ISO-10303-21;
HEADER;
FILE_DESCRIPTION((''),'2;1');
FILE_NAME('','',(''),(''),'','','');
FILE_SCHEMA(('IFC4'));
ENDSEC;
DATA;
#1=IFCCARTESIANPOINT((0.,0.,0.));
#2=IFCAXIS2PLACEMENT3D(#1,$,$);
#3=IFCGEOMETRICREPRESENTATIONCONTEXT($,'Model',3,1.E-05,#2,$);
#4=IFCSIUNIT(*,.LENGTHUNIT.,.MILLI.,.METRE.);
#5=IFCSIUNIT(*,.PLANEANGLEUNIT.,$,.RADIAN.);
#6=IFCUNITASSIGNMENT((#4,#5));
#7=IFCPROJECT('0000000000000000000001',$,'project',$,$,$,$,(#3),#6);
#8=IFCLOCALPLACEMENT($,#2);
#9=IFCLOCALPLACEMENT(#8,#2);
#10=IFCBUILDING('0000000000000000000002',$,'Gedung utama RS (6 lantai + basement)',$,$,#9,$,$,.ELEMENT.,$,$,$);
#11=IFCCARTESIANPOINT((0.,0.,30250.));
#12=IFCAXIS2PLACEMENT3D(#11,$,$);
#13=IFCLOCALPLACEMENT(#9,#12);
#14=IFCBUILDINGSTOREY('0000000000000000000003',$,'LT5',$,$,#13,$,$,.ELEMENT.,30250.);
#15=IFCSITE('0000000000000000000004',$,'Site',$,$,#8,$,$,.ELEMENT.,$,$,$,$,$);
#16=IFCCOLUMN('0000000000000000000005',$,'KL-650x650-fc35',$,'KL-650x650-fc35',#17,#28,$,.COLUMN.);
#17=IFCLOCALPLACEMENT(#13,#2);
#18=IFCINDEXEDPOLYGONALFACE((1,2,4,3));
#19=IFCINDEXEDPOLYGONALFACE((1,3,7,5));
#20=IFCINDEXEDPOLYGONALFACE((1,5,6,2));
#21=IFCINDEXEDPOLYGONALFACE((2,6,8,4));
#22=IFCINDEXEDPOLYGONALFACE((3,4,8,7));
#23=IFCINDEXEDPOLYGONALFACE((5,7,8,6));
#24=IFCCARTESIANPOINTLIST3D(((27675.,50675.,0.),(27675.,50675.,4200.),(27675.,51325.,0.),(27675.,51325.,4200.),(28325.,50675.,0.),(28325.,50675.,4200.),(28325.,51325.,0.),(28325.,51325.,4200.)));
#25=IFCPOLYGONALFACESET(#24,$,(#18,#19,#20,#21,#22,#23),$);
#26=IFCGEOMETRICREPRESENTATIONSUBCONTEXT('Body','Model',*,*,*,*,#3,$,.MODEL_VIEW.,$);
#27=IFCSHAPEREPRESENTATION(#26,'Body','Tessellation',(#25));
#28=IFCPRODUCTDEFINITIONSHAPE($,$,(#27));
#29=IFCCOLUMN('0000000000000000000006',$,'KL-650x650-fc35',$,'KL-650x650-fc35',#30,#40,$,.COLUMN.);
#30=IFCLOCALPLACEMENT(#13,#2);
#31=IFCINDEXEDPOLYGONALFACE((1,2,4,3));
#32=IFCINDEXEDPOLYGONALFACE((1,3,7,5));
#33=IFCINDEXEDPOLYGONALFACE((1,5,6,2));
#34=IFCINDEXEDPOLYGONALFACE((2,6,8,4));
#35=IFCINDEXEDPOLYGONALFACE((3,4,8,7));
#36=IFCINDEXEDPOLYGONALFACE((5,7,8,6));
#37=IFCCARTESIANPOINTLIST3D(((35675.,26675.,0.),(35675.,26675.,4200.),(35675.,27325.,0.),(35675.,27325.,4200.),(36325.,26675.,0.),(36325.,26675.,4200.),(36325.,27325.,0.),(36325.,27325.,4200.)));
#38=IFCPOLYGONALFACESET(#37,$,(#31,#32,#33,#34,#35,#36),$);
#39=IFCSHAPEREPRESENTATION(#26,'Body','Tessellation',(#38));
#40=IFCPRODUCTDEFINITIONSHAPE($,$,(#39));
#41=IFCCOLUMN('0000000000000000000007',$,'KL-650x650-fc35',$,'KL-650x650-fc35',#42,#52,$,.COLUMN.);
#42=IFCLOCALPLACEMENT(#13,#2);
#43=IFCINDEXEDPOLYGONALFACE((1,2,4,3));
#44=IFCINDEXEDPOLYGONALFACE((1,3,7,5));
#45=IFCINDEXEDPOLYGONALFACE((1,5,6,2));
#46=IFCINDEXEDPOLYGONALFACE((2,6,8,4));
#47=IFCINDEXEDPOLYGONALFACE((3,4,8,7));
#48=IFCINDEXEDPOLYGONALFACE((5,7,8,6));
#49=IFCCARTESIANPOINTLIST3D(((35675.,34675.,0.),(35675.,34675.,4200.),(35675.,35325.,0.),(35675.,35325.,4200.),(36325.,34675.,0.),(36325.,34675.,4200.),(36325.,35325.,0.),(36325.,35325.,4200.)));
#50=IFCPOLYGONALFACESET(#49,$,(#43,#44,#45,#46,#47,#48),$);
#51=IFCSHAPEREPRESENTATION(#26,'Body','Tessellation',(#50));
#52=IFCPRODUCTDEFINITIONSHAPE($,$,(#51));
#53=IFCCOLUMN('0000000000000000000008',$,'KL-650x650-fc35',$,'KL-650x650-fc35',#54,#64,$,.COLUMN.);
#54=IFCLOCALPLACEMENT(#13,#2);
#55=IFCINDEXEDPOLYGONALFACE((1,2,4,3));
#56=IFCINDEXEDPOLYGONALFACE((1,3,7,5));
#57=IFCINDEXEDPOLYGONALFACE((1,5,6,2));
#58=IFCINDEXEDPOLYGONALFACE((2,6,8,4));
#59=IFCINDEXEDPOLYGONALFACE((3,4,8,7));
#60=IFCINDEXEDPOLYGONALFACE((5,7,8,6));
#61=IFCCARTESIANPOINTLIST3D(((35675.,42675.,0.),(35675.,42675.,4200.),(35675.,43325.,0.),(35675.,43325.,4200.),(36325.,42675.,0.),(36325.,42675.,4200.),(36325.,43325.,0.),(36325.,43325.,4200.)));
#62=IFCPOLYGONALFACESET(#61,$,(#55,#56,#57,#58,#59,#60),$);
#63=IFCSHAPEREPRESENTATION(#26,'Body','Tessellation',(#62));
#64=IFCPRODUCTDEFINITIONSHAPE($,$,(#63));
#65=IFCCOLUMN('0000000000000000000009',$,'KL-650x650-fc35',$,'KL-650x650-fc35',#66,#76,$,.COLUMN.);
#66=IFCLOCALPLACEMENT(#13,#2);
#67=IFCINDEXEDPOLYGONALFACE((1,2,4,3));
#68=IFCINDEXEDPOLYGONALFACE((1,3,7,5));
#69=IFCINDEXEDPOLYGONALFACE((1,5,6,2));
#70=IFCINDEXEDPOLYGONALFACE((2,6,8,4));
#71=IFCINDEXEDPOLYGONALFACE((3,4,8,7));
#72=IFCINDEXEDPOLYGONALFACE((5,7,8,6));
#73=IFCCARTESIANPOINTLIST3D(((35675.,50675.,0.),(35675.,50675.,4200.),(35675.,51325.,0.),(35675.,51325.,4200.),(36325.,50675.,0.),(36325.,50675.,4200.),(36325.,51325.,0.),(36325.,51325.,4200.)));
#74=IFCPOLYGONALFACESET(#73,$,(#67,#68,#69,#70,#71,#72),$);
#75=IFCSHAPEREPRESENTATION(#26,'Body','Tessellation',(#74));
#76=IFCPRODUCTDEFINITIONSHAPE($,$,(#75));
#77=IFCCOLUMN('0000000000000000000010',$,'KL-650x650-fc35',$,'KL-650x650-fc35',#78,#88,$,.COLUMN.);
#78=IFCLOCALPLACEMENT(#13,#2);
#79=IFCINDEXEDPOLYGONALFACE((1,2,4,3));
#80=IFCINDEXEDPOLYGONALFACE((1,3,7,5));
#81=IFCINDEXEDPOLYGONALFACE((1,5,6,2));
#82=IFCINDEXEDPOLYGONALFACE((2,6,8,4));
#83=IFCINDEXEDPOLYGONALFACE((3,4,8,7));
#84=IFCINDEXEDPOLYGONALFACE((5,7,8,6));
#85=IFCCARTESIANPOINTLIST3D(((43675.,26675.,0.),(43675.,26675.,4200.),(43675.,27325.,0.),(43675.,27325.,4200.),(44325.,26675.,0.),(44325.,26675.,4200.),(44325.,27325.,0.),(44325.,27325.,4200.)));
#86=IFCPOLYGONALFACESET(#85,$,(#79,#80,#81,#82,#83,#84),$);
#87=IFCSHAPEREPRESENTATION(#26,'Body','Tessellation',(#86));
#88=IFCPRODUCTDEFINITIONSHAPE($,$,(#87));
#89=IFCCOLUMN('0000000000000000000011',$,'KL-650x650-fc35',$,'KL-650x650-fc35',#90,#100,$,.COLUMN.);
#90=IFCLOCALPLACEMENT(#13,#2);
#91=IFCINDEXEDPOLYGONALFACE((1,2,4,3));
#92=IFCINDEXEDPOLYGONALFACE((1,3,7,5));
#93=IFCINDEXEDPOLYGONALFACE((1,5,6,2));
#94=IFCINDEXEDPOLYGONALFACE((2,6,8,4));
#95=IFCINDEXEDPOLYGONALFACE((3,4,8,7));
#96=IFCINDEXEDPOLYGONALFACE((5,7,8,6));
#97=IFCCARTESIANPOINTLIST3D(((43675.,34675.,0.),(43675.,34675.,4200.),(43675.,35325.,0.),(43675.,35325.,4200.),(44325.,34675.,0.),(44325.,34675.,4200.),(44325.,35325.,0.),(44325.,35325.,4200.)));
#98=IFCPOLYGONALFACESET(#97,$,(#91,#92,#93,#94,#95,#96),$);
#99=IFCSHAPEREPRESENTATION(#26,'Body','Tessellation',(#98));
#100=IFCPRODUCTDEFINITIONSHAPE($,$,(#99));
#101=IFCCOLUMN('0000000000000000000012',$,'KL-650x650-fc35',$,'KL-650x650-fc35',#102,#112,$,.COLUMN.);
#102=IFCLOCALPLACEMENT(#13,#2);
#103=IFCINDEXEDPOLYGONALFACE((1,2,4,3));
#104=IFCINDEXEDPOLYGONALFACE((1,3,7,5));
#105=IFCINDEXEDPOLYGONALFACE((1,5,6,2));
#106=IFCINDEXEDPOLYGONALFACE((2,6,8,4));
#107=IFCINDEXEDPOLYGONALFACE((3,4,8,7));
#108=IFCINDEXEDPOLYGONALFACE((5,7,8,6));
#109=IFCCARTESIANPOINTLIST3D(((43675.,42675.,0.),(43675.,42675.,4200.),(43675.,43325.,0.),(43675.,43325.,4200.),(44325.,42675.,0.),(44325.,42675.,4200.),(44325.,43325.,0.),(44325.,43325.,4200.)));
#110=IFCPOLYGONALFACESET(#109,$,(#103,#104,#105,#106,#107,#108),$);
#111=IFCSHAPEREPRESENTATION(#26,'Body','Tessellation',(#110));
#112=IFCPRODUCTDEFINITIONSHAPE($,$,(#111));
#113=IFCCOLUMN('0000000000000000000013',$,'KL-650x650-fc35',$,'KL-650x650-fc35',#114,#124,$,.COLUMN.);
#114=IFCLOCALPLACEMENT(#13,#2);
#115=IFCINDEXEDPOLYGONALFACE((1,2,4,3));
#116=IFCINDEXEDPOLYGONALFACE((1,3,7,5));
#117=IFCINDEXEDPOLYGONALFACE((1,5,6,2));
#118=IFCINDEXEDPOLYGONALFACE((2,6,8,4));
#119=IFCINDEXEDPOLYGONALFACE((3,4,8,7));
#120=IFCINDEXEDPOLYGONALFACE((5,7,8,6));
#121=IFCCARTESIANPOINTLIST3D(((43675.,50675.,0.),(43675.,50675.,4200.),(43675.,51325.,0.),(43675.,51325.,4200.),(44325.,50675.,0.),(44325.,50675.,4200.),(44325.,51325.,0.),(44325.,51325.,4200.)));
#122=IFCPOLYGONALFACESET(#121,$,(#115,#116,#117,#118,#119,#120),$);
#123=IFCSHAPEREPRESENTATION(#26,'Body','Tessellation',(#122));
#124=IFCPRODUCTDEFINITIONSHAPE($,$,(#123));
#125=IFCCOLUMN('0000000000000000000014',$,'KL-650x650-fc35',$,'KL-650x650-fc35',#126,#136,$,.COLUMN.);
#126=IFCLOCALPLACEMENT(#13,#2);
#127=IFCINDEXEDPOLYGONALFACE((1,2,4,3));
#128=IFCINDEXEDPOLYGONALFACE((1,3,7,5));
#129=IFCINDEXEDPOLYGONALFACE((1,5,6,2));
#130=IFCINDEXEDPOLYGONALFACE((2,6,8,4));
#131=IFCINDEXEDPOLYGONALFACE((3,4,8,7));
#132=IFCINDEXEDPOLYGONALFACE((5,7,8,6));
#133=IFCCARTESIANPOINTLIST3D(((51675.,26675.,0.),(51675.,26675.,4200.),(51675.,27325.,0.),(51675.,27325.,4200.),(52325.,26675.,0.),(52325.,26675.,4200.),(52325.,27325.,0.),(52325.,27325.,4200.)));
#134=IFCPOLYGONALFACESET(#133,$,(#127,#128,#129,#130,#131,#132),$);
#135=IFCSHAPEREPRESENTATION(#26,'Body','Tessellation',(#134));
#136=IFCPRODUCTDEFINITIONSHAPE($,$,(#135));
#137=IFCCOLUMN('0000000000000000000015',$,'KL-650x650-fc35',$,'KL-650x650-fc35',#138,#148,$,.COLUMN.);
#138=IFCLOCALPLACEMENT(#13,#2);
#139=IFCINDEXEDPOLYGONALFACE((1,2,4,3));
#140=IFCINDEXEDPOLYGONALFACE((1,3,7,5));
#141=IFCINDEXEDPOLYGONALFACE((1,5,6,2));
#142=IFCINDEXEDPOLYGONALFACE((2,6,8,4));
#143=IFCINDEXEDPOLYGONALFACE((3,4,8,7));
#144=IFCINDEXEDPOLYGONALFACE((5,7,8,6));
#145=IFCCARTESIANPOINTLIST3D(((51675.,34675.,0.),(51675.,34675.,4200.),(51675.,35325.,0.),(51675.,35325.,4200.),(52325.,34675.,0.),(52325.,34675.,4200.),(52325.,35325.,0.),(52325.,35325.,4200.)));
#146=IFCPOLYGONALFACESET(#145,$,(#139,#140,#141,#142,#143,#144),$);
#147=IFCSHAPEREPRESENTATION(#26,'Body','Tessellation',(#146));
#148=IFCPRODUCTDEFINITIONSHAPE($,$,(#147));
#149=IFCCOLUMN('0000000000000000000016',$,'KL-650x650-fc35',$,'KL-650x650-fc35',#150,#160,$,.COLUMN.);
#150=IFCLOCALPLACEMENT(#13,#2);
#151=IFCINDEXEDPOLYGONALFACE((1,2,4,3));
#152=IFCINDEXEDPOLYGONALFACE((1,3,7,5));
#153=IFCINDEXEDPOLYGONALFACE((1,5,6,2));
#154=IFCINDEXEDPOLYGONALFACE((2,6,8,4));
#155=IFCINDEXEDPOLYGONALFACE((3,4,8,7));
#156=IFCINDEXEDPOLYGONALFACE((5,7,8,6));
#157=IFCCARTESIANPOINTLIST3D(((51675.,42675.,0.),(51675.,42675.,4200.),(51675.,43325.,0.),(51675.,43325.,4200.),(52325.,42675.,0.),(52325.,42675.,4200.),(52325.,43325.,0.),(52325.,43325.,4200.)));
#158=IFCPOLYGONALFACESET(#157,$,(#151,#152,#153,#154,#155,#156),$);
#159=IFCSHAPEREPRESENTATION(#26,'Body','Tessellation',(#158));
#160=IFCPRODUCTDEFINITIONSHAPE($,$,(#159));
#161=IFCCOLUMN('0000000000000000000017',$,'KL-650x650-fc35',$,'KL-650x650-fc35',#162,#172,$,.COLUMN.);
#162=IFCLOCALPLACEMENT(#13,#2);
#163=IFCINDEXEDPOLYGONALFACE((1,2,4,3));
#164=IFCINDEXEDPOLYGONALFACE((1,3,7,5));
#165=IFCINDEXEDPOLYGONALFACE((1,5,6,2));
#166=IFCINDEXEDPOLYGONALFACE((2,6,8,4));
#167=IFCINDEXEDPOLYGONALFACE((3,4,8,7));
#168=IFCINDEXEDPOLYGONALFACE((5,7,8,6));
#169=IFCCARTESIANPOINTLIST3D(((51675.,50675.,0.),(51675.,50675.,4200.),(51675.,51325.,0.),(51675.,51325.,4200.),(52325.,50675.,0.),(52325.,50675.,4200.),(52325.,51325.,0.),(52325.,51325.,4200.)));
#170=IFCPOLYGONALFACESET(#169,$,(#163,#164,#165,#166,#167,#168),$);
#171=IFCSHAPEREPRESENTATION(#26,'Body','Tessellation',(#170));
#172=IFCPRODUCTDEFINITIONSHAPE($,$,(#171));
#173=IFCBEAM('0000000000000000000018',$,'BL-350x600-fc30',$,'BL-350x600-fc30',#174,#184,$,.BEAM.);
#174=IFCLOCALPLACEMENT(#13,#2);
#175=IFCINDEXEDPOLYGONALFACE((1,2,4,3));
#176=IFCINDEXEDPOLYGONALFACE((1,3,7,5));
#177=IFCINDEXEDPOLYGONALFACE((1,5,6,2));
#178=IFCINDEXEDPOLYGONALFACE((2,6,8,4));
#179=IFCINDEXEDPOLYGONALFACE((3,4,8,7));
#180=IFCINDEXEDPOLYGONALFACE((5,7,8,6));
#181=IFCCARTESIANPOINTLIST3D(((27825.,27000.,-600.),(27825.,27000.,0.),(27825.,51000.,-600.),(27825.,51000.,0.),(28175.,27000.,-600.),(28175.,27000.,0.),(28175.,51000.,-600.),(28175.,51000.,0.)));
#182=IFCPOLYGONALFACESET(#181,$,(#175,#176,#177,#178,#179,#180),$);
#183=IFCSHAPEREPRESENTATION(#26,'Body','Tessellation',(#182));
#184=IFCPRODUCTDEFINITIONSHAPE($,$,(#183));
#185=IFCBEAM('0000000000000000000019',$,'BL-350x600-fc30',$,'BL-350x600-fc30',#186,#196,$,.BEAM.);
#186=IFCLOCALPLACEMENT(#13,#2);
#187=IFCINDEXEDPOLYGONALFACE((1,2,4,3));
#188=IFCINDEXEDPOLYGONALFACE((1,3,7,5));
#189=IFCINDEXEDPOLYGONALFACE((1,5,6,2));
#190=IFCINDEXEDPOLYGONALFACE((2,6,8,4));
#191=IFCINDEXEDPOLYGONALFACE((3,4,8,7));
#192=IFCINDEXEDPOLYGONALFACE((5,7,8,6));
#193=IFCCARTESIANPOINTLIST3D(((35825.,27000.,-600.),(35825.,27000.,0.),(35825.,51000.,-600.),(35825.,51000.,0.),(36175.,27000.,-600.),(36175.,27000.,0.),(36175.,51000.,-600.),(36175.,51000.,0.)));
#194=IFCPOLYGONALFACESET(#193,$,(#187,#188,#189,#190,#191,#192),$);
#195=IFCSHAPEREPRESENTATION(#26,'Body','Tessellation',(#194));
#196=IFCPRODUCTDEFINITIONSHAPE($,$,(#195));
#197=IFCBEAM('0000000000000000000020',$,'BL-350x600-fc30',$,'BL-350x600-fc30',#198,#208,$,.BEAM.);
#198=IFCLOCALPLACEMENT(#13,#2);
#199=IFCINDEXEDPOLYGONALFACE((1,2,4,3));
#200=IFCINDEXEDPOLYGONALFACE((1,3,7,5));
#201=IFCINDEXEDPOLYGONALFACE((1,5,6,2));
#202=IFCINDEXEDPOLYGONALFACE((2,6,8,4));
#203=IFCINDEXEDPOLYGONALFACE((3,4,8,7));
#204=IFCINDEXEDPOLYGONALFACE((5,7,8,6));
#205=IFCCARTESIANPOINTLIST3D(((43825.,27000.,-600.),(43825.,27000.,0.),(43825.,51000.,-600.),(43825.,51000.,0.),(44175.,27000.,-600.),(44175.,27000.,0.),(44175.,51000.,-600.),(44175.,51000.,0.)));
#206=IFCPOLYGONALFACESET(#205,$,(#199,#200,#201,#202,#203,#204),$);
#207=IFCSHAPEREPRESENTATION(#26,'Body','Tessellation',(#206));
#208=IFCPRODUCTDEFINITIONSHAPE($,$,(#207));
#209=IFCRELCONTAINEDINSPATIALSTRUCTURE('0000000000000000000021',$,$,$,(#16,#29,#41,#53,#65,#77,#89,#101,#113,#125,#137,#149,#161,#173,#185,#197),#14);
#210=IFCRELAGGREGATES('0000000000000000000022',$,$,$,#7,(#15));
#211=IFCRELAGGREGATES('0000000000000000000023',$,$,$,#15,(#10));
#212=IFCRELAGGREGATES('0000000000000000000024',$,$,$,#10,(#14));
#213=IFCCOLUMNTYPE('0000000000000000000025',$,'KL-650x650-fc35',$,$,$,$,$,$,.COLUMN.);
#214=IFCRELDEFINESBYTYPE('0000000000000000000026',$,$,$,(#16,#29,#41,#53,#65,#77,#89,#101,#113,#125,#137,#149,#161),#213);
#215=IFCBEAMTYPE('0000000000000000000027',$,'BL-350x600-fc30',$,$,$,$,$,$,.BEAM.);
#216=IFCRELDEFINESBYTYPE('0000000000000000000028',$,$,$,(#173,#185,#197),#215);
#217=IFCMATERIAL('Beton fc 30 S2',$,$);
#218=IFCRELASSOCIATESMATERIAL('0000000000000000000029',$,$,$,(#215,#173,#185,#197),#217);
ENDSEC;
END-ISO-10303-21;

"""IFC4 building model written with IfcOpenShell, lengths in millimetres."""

from ifc_helpers import new_model, si_unit, frame, origin, origin_2d, place, context, subcontext, project, spatial, rectangle, extrude, material, material_profile, profile_set, profile_usage, type_object, element, save


model = new_model("IFC4")

# Units and contexts
model_context = context("Model", 3, precision=1e-05, world=origin())
body_context = subcontext(model_context, "Body", "Model", "MODEL_VIEW")
ifc_project = project(units=[si_unit("LENGTHUNIT", "METRE", prefix="MILLI"), si_unit("PLANEANGLEUNIT", "RADIAN")], contexts=[model_context])

# Site, building, storey
site_placement = place(None, origin())
site = spatial("IfcSite", under=ifc_project, at=site_placement, Name="Site", CompositionType="ELEMENT")
building_placement = place(site_placement, origin())
building = spatial("IfcBuilding", under=site, at=building_placement, Name="Gedung utama RS (6 lantai + basement)", CompositionType="ELEMENT")
storey_placement = place(building_placement, frame((0.0, 0.0, 30250.0)))
storey = spatial("IfcBuildingStorey", under=building, at=storey_placement, Name="LT5", CompositionType="ELEMENT", Elevation=30250.0)

# Columns
ifc_material_profile_1 = material_profile(None, rectangle(XDim=650.0, YDim=650.0, at=origin_2d()), Name="KL-650x650-fc35")
ifc_profile_set_1 = profile_set([ifc_material_profile_1], Name="KL-650x650-fc35")
ifc_profile_usage_1 = profile_usage(ifc_profile_set_1, cardinal=5)
column_type = type_object("IfcColumnType", Name="KL-650x650-fc35", PredefinedType="COLUMN", material=ifc_profile_set_1)
for number, where, z_axis, x_axis, name in (
    (1, (28000.0, 51000.0, 0.0), (0.0, 0.0, 1.0), (1.0, 0.0, 0.0), "KL-650x650-fc35"),
    (2, (36000.0, 27000.0, 0.0), (0.0, 0.0, 1.0), (1.0, 0.0, 0.0), "KL-650x650-fc35"),
    (3, (36000.0, 35000.0, 0.0), (0.0, 0.0, 1.0), (1.0, 0.0, 0.0), "KL-650x650-fc35"),
    (4, (36000.0, 43000.0, 0.0), (0.0, 0.0, 1.0), (1.0, 0.0, 0.0), "KL-650x650-fc35"),
    (5, (36000.0, 51000.0, 0.0), (0.0, 0.0, 1.0), (1.0, 0.0, 0.0), "KL-650x650-fc35"),
    (6, (44000.0, 27000.0, 0.0), (0.0, 0.0, 1.0), (1.0, 0.0, 0.0), "KL-650x650-fc35"),
    (7, (44000.0, 35000.0, 0.0), (0.0, 0.0, 1.0), (1.0, 0.0, 0.0), "KL-650x650-fc35"),
    (8, (44000.0, 43000.0, 0.0), (0.0, 0.0, 1.0), (1.0, 0.0, 0.0), "KL-650x650-fc35"),
    (9, (44000.0, 51000.0, 0.0), (0.0, 0.0, 1.0), (1.0, 0.0, 0.0), "KL-650x650-fc35"),
    (10, (52000.0, 27000.0, 0.0), (0.0, 0.0, 1.0), (1.0, 0.0, 0.0), "KL-650x650-fc35"),
    (11, (52000.0, 35000.0, 0.0), (0.0, 0.0, 1.0), (1.0, 0.0, 0.0), "KL-650x650-fc35"),
    (12, (52000.0, 43000.0, 0.0), (0.0, 0.0, 1.0), (1.0, 0.0, 0.0), "KL-650x650-fc35"),
    (13, (52000.0, 51000.0, 0.0), (0.0, 0.0, 1.0), (1.0, 0.0, 0.0), "KL-650x650-fc35"),
):
    element("IfcColumn", number, at=place(storey_placement, frame(where, z_axis=z_axis, x_axis=x_axis)), inside=storey, type_object=column_type, material=ifc_profile_usage_1, Name=name, ObjectType="KL-650x650-fc35", PredefinedType="COLUMN", context=body_context, shape_type="SweptSolid", body=[
        extrude(rectangle(XDim=650.0, YDim=650.0, at=origin_2d()), origin(), (0.0, 0.0, 1.0), 4200.0),
    ])

# Beams
ifc_material = material(Name="Beton fc 30 S2")
ifc_material_profile_2 = material_profile(ifc_material, rectangle(XDim=350.0, YDim=600.0, at=origin_2d()), Name="BL-350x600-fc30")
ifc_profile_set_2 = profile_set([ifc_material_profile_2], Name="BL-350x600-fc30")
ifc_profile_usage_2 = profile_usage(ifc_profile_set_2, cardinal=8)
beam_type = type_object("IfcBeamType", Name="BL-350x600-fc30", PredefinedType="BEAM", material=ifc_profile_set_2)
for number, where, name in (
    (14, (28000.0, 27000.0, -300.0), "BL-350x600-fc30"),
    (15, (36000.0, 27000.0, -300.0), "BL-350x600-fc30"),
    (16, (44000.0, 27000.0, -300.0), "BL-350x600-fc30"),
):
    element("IfcBeam", number, at=place(storey_placement, frame(where)), inside=storey, type_object=beam_type, material=ifc_profile_usage_2, Name=name, ObjectType="BL-350x600-fc30", PredefinedType="BEAM", context=body_context, shape_type="SweptSolid", body=[
        extrude(rectangle(XDim=350.0, YDim=600.0, at=origin_2d()), frame((0.0, 0.0, 0.0), z_axis=(0.0, 1.0, 0.0), x_axis=(-1.0, 0.0, 0.0)), (0.0, 0.0, 1.0), 24000.0),
    ])

save(model, "model.ifc")
